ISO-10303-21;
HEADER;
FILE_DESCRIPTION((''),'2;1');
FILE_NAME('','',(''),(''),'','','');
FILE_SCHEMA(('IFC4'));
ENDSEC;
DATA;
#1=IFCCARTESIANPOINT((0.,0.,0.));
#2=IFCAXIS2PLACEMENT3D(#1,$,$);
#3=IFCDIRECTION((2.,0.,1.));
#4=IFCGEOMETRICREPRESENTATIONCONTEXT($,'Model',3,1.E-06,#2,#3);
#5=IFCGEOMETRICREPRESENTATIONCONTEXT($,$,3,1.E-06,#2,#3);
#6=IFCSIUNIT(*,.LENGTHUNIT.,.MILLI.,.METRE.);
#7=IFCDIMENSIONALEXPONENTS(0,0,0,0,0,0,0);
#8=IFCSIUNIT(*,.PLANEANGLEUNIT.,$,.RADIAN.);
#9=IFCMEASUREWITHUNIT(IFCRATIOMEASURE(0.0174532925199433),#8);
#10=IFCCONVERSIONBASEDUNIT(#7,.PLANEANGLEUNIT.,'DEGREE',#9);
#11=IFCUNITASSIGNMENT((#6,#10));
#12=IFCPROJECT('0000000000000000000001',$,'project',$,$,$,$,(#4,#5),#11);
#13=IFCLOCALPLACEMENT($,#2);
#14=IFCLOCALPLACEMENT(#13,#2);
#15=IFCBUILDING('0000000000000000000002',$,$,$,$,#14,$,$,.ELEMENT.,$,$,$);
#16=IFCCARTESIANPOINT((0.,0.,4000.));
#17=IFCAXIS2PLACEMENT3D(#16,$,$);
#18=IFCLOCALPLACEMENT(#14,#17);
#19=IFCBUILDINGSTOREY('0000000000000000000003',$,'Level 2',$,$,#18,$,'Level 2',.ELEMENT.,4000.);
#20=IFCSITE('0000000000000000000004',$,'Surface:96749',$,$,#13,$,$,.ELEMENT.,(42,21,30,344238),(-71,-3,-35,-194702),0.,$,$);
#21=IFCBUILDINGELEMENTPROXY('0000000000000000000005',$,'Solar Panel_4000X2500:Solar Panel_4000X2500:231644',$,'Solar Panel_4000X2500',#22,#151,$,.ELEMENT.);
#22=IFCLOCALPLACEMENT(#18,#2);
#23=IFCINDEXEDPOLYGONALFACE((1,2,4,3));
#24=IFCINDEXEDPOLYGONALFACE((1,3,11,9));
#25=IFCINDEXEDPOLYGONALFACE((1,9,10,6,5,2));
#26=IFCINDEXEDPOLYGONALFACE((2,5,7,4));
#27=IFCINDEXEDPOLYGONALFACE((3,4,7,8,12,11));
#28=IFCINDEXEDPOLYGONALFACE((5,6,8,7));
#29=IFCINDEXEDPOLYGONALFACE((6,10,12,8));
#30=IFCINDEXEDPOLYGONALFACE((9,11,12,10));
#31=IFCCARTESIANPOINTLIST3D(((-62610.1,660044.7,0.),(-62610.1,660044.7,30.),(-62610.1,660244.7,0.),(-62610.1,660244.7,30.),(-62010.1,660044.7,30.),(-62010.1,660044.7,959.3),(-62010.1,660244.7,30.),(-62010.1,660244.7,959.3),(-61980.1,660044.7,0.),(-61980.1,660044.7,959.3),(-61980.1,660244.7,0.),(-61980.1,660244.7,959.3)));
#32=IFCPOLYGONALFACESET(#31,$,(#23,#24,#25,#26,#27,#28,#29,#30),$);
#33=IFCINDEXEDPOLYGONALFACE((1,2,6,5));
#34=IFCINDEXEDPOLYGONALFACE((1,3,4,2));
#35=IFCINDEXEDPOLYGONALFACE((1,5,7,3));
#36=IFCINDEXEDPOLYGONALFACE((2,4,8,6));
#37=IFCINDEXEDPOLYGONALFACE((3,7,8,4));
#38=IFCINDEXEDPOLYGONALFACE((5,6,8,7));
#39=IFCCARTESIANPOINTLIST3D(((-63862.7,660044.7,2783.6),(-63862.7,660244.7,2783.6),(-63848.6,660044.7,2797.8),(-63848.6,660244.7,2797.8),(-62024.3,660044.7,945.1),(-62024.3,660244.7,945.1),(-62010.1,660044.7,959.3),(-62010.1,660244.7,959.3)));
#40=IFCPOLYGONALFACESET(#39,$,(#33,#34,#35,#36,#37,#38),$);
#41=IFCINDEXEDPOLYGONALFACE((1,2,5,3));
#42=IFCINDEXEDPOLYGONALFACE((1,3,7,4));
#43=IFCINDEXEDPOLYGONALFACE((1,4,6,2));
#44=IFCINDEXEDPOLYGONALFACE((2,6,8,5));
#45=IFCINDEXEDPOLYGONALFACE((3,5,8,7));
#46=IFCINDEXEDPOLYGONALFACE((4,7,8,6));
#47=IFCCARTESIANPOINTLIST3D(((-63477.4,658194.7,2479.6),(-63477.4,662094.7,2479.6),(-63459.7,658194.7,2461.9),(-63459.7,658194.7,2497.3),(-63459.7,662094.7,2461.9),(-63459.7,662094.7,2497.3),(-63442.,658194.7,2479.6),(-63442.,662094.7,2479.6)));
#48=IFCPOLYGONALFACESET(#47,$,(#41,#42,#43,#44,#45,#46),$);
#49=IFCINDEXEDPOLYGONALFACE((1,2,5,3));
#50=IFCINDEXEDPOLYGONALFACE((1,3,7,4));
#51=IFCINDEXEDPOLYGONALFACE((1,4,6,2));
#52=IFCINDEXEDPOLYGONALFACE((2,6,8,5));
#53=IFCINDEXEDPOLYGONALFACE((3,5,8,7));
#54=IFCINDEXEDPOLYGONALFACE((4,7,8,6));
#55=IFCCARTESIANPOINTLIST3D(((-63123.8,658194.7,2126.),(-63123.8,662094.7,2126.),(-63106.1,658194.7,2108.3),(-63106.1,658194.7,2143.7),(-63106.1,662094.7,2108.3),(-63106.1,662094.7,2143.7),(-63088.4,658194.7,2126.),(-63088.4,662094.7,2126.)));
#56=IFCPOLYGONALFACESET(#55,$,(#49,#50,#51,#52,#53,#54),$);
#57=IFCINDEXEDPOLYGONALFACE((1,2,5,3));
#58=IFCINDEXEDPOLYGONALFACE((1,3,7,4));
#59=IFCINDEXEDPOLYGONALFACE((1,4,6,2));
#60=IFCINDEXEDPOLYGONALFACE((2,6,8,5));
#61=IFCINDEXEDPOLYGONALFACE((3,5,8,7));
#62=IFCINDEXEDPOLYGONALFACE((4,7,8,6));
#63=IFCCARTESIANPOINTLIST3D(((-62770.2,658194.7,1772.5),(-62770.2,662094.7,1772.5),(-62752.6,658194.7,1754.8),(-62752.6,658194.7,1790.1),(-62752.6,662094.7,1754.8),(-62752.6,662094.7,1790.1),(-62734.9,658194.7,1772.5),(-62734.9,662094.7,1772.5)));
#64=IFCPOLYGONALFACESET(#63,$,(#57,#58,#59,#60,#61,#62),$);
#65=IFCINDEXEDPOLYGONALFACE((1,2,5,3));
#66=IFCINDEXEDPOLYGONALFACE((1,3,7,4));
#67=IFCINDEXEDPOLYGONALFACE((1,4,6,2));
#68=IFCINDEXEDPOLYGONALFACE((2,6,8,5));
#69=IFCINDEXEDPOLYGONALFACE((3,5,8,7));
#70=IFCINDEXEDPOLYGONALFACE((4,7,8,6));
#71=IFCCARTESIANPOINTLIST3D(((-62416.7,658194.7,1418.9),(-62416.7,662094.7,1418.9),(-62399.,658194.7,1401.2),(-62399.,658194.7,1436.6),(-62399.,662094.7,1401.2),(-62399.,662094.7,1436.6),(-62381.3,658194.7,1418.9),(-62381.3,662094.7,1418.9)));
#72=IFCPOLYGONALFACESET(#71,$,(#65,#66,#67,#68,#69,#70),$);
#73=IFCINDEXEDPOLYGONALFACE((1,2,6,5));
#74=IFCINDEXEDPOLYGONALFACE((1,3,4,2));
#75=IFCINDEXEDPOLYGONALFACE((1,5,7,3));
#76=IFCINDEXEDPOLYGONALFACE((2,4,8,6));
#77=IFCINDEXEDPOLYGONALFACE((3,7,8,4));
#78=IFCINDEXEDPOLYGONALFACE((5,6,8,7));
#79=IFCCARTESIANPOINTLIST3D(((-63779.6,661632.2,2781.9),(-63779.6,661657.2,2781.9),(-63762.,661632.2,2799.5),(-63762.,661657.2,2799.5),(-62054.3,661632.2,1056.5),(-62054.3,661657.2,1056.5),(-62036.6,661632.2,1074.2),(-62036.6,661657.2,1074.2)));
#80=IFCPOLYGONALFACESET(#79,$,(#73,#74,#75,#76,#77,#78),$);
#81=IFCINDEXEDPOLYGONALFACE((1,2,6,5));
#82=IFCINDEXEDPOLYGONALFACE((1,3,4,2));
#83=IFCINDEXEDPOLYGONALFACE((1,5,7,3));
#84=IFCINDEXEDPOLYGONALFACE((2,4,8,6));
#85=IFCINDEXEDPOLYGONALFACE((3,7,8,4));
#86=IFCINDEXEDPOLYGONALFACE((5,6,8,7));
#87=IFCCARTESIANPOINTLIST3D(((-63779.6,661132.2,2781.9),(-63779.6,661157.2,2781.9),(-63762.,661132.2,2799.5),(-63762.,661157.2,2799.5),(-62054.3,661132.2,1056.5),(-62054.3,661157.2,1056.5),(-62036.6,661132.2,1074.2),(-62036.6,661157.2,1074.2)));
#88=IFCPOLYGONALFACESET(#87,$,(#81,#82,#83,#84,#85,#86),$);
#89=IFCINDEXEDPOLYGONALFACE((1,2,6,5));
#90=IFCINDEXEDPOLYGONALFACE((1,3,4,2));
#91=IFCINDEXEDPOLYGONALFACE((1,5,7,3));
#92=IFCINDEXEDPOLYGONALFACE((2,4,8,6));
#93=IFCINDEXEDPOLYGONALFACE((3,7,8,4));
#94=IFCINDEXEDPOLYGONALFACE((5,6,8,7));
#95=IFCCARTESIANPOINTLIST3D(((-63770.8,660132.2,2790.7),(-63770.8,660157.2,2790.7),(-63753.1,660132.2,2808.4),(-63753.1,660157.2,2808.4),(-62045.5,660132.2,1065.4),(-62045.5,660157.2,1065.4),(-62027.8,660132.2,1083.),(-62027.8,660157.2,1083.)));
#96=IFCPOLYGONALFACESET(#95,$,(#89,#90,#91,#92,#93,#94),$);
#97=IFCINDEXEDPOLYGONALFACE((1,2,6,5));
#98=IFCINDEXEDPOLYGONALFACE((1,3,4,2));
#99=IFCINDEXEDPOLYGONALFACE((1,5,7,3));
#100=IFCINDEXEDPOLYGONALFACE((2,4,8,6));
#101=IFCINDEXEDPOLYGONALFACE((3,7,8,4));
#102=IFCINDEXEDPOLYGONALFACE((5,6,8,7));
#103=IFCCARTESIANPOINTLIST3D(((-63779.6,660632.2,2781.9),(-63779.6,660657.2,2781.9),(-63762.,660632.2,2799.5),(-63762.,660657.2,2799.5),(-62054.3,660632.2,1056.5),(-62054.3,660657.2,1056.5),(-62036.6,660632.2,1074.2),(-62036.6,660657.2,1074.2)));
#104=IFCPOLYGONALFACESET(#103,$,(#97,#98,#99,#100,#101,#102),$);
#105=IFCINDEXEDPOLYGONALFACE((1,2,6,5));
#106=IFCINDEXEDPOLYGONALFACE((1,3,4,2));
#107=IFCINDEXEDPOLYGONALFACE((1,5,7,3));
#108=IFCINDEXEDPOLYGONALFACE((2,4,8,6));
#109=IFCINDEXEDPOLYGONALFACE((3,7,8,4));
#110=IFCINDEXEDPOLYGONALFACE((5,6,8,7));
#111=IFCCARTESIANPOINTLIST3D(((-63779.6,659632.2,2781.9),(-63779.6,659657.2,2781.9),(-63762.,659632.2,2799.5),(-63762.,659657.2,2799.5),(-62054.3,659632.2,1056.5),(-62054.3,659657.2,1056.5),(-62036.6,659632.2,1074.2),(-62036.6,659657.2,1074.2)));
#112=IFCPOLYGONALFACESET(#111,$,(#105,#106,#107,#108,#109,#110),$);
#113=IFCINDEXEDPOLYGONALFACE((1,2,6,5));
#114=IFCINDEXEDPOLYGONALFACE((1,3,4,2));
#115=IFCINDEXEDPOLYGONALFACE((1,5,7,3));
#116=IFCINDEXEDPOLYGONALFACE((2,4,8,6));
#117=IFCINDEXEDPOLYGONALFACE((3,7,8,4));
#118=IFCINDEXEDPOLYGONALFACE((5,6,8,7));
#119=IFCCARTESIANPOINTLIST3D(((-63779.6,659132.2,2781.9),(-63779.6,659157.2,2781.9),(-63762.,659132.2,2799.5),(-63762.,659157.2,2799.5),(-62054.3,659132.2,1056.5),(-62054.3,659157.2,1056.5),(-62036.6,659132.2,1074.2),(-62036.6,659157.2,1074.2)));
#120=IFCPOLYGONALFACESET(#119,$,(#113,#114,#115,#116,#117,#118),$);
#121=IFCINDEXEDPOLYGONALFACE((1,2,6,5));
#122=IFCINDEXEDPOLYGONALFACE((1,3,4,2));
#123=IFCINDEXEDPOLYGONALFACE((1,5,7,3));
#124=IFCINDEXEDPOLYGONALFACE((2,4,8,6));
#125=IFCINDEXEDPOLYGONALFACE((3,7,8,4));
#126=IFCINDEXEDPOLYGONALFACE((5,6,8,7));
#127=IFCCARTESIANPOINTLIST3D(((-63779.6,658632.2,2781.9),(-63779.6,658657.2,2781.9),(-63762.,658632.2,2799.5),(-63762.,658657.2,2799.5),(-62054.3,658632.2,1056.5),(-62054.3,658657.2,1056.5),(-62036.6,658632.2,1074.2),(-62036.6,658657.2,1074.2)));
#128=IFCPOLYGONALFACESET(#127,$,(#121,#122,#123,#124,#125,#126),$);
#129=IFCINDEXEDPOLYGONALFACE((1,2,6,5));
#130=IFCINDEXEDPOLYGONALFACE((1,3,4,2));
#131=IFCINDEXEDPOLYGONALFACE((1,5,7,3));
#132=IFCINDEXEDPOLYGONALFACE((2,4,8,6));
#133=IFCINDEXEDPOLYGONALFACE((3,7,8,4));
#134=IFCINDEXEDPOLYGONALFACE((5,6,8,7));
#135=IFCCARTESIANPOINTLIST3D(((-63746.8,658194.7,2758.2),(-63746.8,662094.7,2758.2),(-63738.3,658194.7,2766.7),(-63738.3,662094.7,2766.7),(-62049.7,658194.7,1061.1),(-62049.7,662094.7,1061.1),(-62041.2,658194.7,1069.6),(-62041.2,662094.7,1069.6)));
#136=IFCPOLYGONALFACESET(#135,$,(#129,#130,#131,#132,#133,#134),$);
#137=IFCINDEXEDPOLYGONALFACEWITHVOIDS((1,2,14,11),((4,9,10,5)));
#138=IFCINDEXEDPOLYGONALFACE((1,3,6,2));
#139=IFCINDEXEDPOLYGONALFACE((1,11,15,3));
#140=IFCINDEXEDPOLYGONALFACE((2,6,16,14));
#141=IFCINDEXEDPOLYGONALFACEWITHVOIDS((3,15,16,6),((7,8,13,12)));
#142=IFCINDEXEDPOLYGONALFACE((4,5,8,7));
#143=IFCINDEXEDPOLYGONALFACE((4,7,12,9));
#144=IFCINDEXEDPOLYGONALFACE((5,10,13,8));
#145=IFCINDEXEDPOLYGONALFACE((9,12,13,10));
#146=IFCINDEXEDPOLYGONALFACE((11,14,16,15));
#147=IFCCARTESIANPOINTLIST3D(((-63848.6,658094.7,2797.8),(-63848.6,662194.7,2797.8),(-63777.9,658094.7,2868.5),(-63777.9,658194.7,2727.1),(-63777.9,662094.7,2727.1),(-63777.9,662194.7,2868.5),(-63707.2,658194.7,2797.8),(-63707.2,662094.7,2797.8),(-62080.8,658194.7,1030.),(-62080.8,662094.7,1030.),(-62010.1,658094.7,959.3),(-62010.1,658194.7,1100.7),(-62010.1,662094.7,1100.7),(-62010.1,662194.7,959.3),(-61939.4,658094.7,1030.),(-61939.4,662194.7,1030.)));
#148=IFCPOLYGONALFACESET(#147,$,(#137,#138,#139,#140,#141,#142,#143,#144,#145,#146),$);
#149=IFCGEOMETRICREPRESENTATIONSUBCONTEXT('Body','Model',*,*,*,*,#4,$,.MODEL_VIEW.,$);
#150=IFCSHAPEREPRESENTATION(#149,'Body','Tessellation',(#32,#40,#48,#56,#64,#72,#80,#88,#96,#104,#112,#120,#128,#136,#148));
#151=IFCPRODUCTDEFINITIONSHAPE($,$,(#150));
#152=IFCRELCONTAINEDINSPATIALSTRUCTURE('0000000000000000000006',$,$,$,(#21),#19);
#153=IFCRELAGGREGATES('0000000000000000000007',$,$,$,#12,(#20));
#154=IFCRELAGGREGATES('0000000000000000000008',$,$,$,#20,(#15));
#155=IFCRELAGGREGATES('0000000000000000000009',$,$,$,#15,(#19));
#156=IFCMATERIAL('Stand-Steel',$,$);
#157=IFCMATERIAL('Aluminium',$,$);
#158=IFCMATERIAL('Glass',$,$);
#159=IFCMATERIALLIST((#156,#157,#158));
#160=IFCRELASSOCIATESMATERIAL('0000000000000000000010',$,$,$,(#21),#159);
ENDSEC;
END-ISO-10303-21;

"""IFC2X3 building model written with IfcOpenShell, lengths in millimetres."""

from ifc_helpers import new_model, entity, si_unit, converted_unit, direction, frame, frame_2d, origin, origin_2d_with_axis, place, context, subcontext, project, spatial, polyline, rectangle, outline, extrude, source, transform, mapped, material, material_list, element, save


model = new_model("IFC2X3")

# Units and contexts
model_context = context("Model", 3, precision=1e-06, world=origin(), true_north=direction((2.0, 0.0, 1.0)))
context_of_model = context(None, 3, precision=1e-06, world=origin(), true_north=direction((2.0, 0.0, 1.0)))
body_context = subcontext(model_context, "Body", "Model", "MODEL_VIEW")
ifc_project = project(units=[si_unit("LENGTHUNIT", "METRE", prefix="MILLI"), converted_unit("PLANEANGLEUNIT", "DEGREE", entity("IfcRatioMeasure", 0.0174532925199433), si_unit("PLANEANGLEUNIT", "RADIAN"), dimensions=[0, 0, 0, 0, 0, 0, 0])], contexts=[model_context, context_of_model])

# Site, building, storey
site_placement = place(None, origin())
site = spatial("IfcSite", under=ifc_project, at=site_placement, Name="Surface:96749", CompositionType="ELEMENT", RefLatitude=(42, 21, 30, 344238), RefLongitude=(-71, -3, -35, -194702), RefElevation=0.0)
building_placement = place(site_placement, origin())
building = spatial("IfcBuilding", under=site, at=building_placement, CompositionType="ELEMENT")
storey_placement = place(building_placement, frame((0.0, 0.0, 4000.0)))
storey = spatial("IfcBuildingStorey", under=building, at=storey_placement, Name="Level 2", LongName="Level 2", CompositionType="ELEMENT", Elevation=4000.0)

# Building element proxy
ifc_material_1 = material(Name="Stand-Steel")
ifc_material_2 = material(Name="Aluminium")
ifc_material_3 = material(Name="Glass")
shared_shape = source(origin(), body_context, "Body", "SweptSolid", [
    extrude(outline(polyline([(-629.5, -220.0), (329.8, -220.0), (329.8, 410.0), (299.8, 410.0), (299.8, -190.0), (-629.5, -190.0), (-629.5, -220.0)])), frame((-190.0, -100.0, 299.8), z_axis=(0.0, 1.0, 0.0), x_axis=(0.0, 0.0, -1.0)), (0.0, 0.0, 1.0), 200.0),
    extrude(rectangle(XDim=20.0, YDim=200.0, at=frame_2d((0.0, 0.0), x_axis=(0.0, 1.0))), frame((-7.1, 0.0, 922.2), z_axis=(-0.707107, 0.0, 0.707107), x_axis=(0.0, 1.0, 0.0)), (0.0, 0.0, 1.0), 2600.0),
    extrude(rectangle(XDim=25.0, YDim=25.0, at=frame_2d((0.0, 0.0), x_axis=(1.0, 0.0))), frame((-1449.6, -1950.0, 2449.6), z_axis=(0.0, 1.0, 0.0), x_axis=(-0.707107, 0.0, -0.707107)), (0.0, 0.0, 1.0), 3900.0),
    extrude(rectangle(XDim=25.0, YDim=25.0, at=origin_2d_with_axis()), frame((-1096.0, -1950.0, 2096.0), z_axis=(0.0, 1.0, 0.0), x_axis=(-0.707107, 0.0, -0.707107)), (0.0, 0.0, 1.0), 3900.0),
    extrude(rectangle(XDim=25.0, YDim=25.0, at=origin_2d_with_axis()), frame((-742.5, -1950.0, 1742.5), z_axis=(0.0, 1.0, 0.0), x_axis=(-0.707107, 0.0, -0.707107)), (0.0, 0.0, 1.0), 3900.0),
    extrude(rectangle(XDim=25.0, YDim=25.0, at=frame_2d((0.0, 0.0), x_axis=(1.0, 0.0))), frame((-388.9, -1950.0, 1388.9), z_axis=(0.0, 1.0, 0.0), x_axis=(-0.707107, 0.0, -0.707107)), (0.0, 0.0, 1.0), 3900.0),
    extrude(rectangle(XDim=25.0, YDim=25.0, at=frame_2d((0.0, 0.0), x_axis=(0.0, 1.0))), frame((-35.4, 1500.0, 1035.4), z_axis=(-0.707107, 0.0, 0.707107), x_axis=(0.0, 1.0, 0.0)), (0.0, 0.0, 1.0), 2440.0),
    extrude(rectangle(XDim=25.0, YDim=25.0, at=frame_2d((0.0, 0.0), x_axis=(0.0, 1.0))), frame((-35.4, 1000.0, 1035.4), z_axis=(-0.707107, 0.0, 0.707107), x_axis=(0.0, 1.0, 0.0)), (0.0, 0.0, 1.0), 2440.0),
    extrude(rectangle(XDim=25.0, YDim=25.0, at=frame_2d((0.0, 0.0), x_axis=(0.0, 1.0))), frame((-26.5, 0.0, 1044.2), z_axis=(-0.707107, 0.0, 0.707107), x_axis=(0.0, -1.0, 0.0)), (0.0, 0.0, 1.0), 2440.0),
    extrude(rectangle(XDim=25.0, YDim=25.0, at=frame_2d((0.0, 0.0), x_axis=(0.0, 1.0))), frame((-35.4, 500.0, 1035.4), z_axis=(-0.707107, 0.0, 0.707107), x_axis=(0.0, 1.0, 0.0)), (0.0, 0.0, 1.0), 2440.0),
    extrude(rectangle(XDim=25.0, YDim=25.0, at=frame_2d((0.0, 0.0), x_axis=(0.0, 1.0))), frame((-35.4, -500.0, 1035.4), z_axis=(-0.707107, 0.0, 0.707107), x_axis=(0.0, 1.0, 0.0)), (0.0, 0.0, 1.0), 2440.0),
    extrude(rectangle(XDim=25.0, YDim=25.0, at=frame_2d((0.0, 0.0), x_axis=(0.0, 1.0))), frame((-35.4, -1000.0, 1035.4), z_axis=(-0.707107, 0.0, 0.707107), x_axis=(0.0, 1.0, 0.0)), (0.0, 0.0, 1.0), 2440.0),
    extrude(rectangle(XDim=25.0, YDim=25.0, at=frame_2d((0.0, 0.0), x_axis=(0.0, 1.0))), frame((-35.4, -1500.0, 1035.4), z_axis=(-0.707107, 0.0, 0.707107), x_axis=(0.0, 1.0, 0.0)), (0.0, 0.0, 1.0), 2440.0),
    extrude(rectangle(XDim=2400.0, YDim=12.0, at=frame_2d((0.0, 0.0), x_axis=(1.0, 0.0))), frame((-883.9, -1950.0, 1883.9), z_axis=(0.0, 1.0, 0.0), x_axis=(0.707107, 0.0, -0.707107)), (0.0, 0.0, 1.0), 3900.0),
    extrude(outline(polyline([(-2050.0, -1300.0), (2050.0, -1300.0), (2050.0, 1300.0), (-2050.0, 1300.0), (-2050.0, -1300.0)]), holes=[polyline([(1950.0, -1200.0), (-1950.0, -1200.0), (-1950.0, 1200.0), (1950.0, 1200.0), (1950.0, -1200.0)])]), frame((-919.2, 0.0, 1848.5), z_axis=(0.707107, 0.0, 0.707107), x_axis=(0.0, 1.0, 0.0)), (0.0, 0.0, 1.0), 100.0),
])
ifc_material_list_1 = material_list([ifc_material_1, ifc_material_2, ifc_material_3])
proxy_1_placement = place(storey_placement, frame((-62010.1, 660144.7, 30.0)))
element("IfcBuildingElementProxy", 1, at=proxy_1_placement, inside=storey, material=ifc_material_list_1, Name="Solar Panel_4000X2500:Solar Panel_4000X2500:231644", ObjectType="Solar Panel_4000X2500", CompositionType="ELEMENT", context=body_context, shape_type="MappedRepresentation", body=[
    mapped(shared_shape, transform((0.0, 0.0, 0.0), scale=1.0)),
])

save(model, "model.ifc")
